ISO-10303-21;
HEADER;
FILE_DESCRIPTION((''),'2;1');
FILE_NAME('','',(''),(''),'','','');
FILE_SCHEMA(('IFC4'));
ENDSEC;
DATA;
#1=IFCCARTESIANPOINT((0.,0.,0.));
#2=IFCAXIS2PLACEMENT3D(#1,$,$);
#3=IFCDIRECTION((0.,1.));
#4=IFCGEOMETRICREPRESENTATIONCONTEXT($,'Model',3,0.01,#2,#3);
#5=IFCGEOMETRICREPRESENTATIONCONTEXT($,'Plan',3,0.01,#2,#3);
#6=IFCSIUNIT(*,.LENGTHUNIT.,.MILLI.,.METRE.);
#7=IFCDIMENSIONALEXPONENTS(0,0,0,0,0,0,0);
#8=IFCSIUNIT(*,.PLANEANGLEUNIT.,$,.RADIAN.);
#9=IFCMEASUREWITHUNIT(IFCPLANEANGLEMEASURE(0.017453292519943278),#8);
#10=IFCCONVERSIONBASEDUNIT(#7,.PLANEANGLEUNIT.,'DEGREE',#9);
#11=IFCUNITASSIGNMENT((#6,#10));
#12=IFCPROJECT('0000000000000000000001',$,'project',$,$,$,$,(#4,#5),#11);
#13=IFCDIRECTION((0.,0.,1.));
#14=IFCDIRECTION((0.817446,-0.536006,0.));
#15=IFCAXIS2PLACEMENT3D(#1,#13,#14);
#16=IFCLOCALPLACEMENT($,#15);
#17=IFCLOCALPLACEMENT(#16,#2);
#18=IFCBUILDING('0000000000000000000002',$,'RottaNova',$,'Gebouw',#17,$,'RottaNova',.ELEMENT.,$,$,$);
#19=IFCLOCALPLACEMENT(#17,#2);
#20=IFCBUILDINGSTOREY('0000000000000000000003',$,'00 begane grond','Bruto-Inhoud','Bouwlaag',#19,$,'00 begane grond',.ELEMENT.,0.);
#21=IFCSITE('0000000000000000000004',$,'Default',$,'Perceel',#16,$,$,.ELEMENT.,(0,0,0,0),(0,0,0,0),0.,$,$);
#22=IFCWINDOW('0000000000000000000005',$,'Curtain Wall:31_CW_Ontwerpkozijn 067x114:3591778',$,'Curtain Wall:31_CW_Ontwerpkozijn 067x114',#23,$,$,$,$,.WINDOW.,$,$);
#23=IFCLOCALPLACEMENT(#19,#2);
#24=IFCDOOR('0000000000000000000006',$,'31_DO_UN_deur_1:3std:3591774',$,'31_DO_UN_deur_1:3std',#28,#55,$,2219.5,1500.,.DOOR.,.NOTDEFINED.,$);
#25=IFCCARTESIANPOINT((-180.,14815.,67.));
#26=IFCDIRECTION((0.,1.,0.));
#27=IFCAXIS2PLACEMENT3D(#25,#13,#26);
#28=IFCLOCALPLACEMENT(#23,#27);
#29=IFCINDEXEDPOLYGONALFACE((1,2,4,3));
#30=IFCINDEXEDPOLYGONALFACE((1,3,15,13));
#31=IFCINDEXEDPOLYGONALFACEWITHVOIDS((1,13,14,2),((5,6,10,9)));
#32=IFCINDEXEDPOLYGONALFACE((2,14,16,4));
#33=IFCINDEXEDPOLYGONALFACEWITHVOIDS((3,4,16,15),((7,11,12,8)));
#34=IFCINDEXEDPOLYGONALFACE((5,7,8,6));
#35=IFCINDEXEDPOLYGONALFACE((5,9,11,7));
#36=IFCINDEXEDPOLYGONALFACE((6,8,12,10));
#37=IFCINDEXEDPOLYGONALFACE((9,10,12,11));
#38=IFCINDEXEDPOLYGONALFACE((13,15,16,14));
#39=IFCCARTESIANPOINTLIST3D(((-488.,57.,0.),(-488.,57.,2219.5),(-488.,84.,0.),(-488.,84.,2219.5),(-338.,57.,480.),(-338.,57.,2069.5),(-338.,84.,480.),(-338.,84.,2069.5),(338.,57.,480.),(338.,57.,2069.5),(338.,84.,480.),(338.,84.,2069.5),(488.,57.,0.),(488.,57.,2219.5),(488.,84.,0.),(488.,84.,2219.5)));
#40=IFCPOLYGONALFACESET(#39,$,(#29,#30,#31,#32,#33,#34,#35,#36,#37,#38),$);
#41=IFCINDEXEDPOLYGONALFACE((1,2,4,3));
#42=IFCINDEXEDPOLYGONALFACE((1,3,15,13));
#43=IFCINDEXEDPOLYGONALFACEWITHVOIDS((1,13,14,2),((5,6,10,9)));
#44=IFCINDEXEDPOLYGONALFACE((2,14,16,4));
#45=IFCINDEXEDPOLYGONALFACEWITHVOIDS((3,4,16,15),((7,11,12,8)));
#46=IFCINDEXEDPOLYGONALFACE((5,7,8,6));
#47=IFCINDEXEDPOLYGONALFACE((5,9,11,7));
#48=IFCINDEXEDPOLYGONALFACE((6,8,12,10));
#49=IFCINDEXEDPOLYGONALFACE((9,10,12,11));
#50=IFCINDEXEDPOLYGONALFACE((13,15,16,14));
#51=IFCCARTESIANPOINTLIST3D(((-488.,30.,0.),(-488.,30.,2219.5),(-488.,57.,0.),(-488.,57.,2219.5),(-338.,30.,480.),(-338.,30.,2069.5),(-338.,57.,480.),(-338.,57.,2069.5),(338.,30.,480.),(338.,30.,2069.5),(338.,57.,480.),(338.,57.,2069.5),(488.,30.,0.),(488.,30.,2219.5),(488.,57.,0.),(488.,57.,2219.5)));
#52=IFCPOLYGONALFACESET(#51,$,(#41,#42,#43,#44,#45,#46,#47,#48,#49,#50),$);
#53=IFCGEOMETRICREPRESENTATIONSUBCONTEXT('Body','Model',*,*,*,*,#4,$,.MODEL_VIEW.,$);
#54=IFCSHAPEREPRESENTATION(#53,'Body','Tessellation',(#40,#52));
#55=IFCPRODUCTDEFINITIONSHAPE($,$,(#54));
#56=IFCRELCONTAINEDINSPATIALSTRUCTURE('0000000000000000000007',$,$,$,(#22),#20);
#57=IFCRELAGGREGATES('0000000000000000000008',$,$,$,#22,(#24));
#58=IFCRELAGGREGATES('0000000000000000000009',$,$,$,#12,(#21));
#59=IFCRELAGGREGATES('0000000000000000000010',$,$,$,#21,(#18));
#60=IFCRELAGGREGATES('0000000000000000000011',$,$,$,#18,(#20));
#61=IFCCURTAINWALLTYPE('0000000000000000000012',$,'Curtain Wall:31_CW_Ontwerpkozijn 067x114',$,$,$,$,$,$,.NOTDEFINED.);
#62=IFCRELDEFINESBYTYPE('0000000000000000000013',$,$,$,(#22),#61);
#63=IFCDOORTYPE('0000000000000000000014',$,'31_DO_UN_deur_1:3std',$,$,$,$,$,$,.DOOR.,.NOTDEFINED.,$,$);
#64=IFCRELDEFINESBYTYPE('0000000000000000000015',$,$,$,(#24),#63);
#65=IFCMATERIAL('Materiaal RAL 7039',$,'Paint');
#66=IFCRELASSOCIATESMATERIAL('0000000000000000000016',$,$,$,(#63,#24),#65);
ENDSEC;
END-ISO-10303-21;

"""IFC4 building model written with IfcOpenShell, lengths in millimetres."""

from ifc_helpers import new_model, entity, si_unit, converted_unit, direction, frame, origin, place, context, subcontext, project, spatial, indexed_curve, outline, extrude, source, transform, mapped, material, type_object, type_shapes, element, aggregate, save


model = new_model("IFC4")

# Units and contexts
model_context = context("Model", 3, precision=0.01, world=origin(), true_north=direction((0.0, 1.0)))
plan_context = context("Plan", 3, precision=0.01, world=origin(), true_north=direction((0.0, 1.0)))
body_context = subcontext(model_context, "Body", "Model", "MODEL_VIEW")
ifc_project = project(units=[si_unit("LENGTHUNIT", "METRE", prefix="MILLI"), converted_unit("PLANEANGLEUNIT", "DEGREE", entity("IfcPlaneAngleMeasure", 0.017453292519943278), si_unit("PLANEANGLEUNIT", "RADIAN"), dimensions=[0, 0, 0, 0, 0, 0, 0])], contexts=[model_context, plan_context])

# Site, building, storey
site_placement = place(None, frame((0.0, 0.0, 0.0), z_axis=(0.0, 0.0, 1.0), x_axis=(0.817446, -0.536006, 0.0)))
site = spatial("IfcSite", under=ifc_project, at=site_placement, Name="Default", ObjectType="Perceel", CompositionType="ELEMENT", RefLatitude=(0, 0, 0, 0), RefLongitude=(0, 0, 0, 0), RefElevation=0.0)
building_placement = place(site_placement, origin())
building = spatial("IfcBuilding", under=site, at=building_placement, Name="RottaNova", ObjectType="Gebouw", LongName="RottaNova", CompositionType="ELEMENT")
storey_placement = place(building_placement, origin())
storey = spatial("IfcBuildingStorey", under=building, at=storey_placement, Name="00 begane grond", Description="Bruto-Inhoud", ObjectType="Bouwlaag", LongName="00 begane grond", CompositionType="ELEMENT", Elevation=0.0)

# Window
curtain_wall_type = type_object("IfcCurtainWallType", Name="Curtain Wall:31_CW_Ontwerpkozijn 067x114", PredefinedType="NOTDEFINED")
window_1_placement = place(storey_placement, origin())
window_1 = element("IfcWindow", 1, at=window_1_placement, inside=storey, type_object=curtain_wall_type, Name="Curtain Wall:31_CW_Ontwerpkozijn 067x114:3591778", ObjectType="Curtain Wall:31_CW_Ontwerpkozijn 067x114", PredefinedType="WINDOW")
ifc_material_1 = material(Name="Materiaal RAL 7039", Category="Paint")

# Door
door_type_1 = type_object("IfcDoorType", Name="31_DO_UN_deur_1:3std", OperationType="NOTDEFINED", PredefinedType="DOOR", material=ifc_material_1)
shared_shape_1 = source(origin(), body_context, "Body", "SweptSolid", [
    extrude(outline(indexed_curve([(-488.0, -1109.7), (488.0, -1109.7), (488.0, 1109.7), (-488.0, 1109.7), (-488.0, -1109.7)], self_intersect=False), holes=[indexed_curve([(-338.0, 629.7), (338.0, 629.7), (338.0, -959.7), (-338.0, -959.7), (-338.0, 629.7)], self_intersect=False)]), frame((0.0, 57.0, 1109.7), z_axis=(0.0, 1.0, 0.0), x_axis=(1.0, 0.0, 0.0)), (0.0, 0.0, 1.0), 27.0),
    extrude(outline(indexed_curve([(-488.0, -1109.7), (488.0, -1109.7), (488.0, 1109.7), (-488.0, 1109.7), (-488.0, -1109.7)], self_intersect=False), holes=[indexed_curve([(-338.0, 629.7), (338.0, 629.7), (338.0, -959.7), (-338.0, -959.7), (-338.0, 629.7)], self_intersect=False)]), frame((0.0, 30.0, 1109.7), z_axis=(0.0, 1.0, 0.0), x_axis=(1.0, 0.0, 0.0)), (0.0, 0.0, 1.0), 27.0),
])
type_shapes(door_type_1, [shared_shape_1])
door_1_placement = place(window_1_placement, frame((-180.0, 14815.0, 67.0), z_axis=(0.0, 0.0, 1.0), x_axis=(0.0, 1.0, 0.0)))
door_1 = element("IfcDoor", 2, at=door_1_placement, type_object=door_type_1, material=ifc_material_1, Name="31_DO_UN_deur_1:3std:3591774", ObjectType="31_DO_UN_deur_1:3std", OperationType="NOTDEFINED", OverallHeight=2219.5, OverallWidth=1500.0, PredefinedType="DOOR", context=body_context, shape_type="MappedRepresentation", body=[
    mapped(shared_shape_1, transform((0.0, 0.0, 0.0), scale=1.0)),
])
aggregate(window_1, [door_1])

save(model, "model.ifc")
